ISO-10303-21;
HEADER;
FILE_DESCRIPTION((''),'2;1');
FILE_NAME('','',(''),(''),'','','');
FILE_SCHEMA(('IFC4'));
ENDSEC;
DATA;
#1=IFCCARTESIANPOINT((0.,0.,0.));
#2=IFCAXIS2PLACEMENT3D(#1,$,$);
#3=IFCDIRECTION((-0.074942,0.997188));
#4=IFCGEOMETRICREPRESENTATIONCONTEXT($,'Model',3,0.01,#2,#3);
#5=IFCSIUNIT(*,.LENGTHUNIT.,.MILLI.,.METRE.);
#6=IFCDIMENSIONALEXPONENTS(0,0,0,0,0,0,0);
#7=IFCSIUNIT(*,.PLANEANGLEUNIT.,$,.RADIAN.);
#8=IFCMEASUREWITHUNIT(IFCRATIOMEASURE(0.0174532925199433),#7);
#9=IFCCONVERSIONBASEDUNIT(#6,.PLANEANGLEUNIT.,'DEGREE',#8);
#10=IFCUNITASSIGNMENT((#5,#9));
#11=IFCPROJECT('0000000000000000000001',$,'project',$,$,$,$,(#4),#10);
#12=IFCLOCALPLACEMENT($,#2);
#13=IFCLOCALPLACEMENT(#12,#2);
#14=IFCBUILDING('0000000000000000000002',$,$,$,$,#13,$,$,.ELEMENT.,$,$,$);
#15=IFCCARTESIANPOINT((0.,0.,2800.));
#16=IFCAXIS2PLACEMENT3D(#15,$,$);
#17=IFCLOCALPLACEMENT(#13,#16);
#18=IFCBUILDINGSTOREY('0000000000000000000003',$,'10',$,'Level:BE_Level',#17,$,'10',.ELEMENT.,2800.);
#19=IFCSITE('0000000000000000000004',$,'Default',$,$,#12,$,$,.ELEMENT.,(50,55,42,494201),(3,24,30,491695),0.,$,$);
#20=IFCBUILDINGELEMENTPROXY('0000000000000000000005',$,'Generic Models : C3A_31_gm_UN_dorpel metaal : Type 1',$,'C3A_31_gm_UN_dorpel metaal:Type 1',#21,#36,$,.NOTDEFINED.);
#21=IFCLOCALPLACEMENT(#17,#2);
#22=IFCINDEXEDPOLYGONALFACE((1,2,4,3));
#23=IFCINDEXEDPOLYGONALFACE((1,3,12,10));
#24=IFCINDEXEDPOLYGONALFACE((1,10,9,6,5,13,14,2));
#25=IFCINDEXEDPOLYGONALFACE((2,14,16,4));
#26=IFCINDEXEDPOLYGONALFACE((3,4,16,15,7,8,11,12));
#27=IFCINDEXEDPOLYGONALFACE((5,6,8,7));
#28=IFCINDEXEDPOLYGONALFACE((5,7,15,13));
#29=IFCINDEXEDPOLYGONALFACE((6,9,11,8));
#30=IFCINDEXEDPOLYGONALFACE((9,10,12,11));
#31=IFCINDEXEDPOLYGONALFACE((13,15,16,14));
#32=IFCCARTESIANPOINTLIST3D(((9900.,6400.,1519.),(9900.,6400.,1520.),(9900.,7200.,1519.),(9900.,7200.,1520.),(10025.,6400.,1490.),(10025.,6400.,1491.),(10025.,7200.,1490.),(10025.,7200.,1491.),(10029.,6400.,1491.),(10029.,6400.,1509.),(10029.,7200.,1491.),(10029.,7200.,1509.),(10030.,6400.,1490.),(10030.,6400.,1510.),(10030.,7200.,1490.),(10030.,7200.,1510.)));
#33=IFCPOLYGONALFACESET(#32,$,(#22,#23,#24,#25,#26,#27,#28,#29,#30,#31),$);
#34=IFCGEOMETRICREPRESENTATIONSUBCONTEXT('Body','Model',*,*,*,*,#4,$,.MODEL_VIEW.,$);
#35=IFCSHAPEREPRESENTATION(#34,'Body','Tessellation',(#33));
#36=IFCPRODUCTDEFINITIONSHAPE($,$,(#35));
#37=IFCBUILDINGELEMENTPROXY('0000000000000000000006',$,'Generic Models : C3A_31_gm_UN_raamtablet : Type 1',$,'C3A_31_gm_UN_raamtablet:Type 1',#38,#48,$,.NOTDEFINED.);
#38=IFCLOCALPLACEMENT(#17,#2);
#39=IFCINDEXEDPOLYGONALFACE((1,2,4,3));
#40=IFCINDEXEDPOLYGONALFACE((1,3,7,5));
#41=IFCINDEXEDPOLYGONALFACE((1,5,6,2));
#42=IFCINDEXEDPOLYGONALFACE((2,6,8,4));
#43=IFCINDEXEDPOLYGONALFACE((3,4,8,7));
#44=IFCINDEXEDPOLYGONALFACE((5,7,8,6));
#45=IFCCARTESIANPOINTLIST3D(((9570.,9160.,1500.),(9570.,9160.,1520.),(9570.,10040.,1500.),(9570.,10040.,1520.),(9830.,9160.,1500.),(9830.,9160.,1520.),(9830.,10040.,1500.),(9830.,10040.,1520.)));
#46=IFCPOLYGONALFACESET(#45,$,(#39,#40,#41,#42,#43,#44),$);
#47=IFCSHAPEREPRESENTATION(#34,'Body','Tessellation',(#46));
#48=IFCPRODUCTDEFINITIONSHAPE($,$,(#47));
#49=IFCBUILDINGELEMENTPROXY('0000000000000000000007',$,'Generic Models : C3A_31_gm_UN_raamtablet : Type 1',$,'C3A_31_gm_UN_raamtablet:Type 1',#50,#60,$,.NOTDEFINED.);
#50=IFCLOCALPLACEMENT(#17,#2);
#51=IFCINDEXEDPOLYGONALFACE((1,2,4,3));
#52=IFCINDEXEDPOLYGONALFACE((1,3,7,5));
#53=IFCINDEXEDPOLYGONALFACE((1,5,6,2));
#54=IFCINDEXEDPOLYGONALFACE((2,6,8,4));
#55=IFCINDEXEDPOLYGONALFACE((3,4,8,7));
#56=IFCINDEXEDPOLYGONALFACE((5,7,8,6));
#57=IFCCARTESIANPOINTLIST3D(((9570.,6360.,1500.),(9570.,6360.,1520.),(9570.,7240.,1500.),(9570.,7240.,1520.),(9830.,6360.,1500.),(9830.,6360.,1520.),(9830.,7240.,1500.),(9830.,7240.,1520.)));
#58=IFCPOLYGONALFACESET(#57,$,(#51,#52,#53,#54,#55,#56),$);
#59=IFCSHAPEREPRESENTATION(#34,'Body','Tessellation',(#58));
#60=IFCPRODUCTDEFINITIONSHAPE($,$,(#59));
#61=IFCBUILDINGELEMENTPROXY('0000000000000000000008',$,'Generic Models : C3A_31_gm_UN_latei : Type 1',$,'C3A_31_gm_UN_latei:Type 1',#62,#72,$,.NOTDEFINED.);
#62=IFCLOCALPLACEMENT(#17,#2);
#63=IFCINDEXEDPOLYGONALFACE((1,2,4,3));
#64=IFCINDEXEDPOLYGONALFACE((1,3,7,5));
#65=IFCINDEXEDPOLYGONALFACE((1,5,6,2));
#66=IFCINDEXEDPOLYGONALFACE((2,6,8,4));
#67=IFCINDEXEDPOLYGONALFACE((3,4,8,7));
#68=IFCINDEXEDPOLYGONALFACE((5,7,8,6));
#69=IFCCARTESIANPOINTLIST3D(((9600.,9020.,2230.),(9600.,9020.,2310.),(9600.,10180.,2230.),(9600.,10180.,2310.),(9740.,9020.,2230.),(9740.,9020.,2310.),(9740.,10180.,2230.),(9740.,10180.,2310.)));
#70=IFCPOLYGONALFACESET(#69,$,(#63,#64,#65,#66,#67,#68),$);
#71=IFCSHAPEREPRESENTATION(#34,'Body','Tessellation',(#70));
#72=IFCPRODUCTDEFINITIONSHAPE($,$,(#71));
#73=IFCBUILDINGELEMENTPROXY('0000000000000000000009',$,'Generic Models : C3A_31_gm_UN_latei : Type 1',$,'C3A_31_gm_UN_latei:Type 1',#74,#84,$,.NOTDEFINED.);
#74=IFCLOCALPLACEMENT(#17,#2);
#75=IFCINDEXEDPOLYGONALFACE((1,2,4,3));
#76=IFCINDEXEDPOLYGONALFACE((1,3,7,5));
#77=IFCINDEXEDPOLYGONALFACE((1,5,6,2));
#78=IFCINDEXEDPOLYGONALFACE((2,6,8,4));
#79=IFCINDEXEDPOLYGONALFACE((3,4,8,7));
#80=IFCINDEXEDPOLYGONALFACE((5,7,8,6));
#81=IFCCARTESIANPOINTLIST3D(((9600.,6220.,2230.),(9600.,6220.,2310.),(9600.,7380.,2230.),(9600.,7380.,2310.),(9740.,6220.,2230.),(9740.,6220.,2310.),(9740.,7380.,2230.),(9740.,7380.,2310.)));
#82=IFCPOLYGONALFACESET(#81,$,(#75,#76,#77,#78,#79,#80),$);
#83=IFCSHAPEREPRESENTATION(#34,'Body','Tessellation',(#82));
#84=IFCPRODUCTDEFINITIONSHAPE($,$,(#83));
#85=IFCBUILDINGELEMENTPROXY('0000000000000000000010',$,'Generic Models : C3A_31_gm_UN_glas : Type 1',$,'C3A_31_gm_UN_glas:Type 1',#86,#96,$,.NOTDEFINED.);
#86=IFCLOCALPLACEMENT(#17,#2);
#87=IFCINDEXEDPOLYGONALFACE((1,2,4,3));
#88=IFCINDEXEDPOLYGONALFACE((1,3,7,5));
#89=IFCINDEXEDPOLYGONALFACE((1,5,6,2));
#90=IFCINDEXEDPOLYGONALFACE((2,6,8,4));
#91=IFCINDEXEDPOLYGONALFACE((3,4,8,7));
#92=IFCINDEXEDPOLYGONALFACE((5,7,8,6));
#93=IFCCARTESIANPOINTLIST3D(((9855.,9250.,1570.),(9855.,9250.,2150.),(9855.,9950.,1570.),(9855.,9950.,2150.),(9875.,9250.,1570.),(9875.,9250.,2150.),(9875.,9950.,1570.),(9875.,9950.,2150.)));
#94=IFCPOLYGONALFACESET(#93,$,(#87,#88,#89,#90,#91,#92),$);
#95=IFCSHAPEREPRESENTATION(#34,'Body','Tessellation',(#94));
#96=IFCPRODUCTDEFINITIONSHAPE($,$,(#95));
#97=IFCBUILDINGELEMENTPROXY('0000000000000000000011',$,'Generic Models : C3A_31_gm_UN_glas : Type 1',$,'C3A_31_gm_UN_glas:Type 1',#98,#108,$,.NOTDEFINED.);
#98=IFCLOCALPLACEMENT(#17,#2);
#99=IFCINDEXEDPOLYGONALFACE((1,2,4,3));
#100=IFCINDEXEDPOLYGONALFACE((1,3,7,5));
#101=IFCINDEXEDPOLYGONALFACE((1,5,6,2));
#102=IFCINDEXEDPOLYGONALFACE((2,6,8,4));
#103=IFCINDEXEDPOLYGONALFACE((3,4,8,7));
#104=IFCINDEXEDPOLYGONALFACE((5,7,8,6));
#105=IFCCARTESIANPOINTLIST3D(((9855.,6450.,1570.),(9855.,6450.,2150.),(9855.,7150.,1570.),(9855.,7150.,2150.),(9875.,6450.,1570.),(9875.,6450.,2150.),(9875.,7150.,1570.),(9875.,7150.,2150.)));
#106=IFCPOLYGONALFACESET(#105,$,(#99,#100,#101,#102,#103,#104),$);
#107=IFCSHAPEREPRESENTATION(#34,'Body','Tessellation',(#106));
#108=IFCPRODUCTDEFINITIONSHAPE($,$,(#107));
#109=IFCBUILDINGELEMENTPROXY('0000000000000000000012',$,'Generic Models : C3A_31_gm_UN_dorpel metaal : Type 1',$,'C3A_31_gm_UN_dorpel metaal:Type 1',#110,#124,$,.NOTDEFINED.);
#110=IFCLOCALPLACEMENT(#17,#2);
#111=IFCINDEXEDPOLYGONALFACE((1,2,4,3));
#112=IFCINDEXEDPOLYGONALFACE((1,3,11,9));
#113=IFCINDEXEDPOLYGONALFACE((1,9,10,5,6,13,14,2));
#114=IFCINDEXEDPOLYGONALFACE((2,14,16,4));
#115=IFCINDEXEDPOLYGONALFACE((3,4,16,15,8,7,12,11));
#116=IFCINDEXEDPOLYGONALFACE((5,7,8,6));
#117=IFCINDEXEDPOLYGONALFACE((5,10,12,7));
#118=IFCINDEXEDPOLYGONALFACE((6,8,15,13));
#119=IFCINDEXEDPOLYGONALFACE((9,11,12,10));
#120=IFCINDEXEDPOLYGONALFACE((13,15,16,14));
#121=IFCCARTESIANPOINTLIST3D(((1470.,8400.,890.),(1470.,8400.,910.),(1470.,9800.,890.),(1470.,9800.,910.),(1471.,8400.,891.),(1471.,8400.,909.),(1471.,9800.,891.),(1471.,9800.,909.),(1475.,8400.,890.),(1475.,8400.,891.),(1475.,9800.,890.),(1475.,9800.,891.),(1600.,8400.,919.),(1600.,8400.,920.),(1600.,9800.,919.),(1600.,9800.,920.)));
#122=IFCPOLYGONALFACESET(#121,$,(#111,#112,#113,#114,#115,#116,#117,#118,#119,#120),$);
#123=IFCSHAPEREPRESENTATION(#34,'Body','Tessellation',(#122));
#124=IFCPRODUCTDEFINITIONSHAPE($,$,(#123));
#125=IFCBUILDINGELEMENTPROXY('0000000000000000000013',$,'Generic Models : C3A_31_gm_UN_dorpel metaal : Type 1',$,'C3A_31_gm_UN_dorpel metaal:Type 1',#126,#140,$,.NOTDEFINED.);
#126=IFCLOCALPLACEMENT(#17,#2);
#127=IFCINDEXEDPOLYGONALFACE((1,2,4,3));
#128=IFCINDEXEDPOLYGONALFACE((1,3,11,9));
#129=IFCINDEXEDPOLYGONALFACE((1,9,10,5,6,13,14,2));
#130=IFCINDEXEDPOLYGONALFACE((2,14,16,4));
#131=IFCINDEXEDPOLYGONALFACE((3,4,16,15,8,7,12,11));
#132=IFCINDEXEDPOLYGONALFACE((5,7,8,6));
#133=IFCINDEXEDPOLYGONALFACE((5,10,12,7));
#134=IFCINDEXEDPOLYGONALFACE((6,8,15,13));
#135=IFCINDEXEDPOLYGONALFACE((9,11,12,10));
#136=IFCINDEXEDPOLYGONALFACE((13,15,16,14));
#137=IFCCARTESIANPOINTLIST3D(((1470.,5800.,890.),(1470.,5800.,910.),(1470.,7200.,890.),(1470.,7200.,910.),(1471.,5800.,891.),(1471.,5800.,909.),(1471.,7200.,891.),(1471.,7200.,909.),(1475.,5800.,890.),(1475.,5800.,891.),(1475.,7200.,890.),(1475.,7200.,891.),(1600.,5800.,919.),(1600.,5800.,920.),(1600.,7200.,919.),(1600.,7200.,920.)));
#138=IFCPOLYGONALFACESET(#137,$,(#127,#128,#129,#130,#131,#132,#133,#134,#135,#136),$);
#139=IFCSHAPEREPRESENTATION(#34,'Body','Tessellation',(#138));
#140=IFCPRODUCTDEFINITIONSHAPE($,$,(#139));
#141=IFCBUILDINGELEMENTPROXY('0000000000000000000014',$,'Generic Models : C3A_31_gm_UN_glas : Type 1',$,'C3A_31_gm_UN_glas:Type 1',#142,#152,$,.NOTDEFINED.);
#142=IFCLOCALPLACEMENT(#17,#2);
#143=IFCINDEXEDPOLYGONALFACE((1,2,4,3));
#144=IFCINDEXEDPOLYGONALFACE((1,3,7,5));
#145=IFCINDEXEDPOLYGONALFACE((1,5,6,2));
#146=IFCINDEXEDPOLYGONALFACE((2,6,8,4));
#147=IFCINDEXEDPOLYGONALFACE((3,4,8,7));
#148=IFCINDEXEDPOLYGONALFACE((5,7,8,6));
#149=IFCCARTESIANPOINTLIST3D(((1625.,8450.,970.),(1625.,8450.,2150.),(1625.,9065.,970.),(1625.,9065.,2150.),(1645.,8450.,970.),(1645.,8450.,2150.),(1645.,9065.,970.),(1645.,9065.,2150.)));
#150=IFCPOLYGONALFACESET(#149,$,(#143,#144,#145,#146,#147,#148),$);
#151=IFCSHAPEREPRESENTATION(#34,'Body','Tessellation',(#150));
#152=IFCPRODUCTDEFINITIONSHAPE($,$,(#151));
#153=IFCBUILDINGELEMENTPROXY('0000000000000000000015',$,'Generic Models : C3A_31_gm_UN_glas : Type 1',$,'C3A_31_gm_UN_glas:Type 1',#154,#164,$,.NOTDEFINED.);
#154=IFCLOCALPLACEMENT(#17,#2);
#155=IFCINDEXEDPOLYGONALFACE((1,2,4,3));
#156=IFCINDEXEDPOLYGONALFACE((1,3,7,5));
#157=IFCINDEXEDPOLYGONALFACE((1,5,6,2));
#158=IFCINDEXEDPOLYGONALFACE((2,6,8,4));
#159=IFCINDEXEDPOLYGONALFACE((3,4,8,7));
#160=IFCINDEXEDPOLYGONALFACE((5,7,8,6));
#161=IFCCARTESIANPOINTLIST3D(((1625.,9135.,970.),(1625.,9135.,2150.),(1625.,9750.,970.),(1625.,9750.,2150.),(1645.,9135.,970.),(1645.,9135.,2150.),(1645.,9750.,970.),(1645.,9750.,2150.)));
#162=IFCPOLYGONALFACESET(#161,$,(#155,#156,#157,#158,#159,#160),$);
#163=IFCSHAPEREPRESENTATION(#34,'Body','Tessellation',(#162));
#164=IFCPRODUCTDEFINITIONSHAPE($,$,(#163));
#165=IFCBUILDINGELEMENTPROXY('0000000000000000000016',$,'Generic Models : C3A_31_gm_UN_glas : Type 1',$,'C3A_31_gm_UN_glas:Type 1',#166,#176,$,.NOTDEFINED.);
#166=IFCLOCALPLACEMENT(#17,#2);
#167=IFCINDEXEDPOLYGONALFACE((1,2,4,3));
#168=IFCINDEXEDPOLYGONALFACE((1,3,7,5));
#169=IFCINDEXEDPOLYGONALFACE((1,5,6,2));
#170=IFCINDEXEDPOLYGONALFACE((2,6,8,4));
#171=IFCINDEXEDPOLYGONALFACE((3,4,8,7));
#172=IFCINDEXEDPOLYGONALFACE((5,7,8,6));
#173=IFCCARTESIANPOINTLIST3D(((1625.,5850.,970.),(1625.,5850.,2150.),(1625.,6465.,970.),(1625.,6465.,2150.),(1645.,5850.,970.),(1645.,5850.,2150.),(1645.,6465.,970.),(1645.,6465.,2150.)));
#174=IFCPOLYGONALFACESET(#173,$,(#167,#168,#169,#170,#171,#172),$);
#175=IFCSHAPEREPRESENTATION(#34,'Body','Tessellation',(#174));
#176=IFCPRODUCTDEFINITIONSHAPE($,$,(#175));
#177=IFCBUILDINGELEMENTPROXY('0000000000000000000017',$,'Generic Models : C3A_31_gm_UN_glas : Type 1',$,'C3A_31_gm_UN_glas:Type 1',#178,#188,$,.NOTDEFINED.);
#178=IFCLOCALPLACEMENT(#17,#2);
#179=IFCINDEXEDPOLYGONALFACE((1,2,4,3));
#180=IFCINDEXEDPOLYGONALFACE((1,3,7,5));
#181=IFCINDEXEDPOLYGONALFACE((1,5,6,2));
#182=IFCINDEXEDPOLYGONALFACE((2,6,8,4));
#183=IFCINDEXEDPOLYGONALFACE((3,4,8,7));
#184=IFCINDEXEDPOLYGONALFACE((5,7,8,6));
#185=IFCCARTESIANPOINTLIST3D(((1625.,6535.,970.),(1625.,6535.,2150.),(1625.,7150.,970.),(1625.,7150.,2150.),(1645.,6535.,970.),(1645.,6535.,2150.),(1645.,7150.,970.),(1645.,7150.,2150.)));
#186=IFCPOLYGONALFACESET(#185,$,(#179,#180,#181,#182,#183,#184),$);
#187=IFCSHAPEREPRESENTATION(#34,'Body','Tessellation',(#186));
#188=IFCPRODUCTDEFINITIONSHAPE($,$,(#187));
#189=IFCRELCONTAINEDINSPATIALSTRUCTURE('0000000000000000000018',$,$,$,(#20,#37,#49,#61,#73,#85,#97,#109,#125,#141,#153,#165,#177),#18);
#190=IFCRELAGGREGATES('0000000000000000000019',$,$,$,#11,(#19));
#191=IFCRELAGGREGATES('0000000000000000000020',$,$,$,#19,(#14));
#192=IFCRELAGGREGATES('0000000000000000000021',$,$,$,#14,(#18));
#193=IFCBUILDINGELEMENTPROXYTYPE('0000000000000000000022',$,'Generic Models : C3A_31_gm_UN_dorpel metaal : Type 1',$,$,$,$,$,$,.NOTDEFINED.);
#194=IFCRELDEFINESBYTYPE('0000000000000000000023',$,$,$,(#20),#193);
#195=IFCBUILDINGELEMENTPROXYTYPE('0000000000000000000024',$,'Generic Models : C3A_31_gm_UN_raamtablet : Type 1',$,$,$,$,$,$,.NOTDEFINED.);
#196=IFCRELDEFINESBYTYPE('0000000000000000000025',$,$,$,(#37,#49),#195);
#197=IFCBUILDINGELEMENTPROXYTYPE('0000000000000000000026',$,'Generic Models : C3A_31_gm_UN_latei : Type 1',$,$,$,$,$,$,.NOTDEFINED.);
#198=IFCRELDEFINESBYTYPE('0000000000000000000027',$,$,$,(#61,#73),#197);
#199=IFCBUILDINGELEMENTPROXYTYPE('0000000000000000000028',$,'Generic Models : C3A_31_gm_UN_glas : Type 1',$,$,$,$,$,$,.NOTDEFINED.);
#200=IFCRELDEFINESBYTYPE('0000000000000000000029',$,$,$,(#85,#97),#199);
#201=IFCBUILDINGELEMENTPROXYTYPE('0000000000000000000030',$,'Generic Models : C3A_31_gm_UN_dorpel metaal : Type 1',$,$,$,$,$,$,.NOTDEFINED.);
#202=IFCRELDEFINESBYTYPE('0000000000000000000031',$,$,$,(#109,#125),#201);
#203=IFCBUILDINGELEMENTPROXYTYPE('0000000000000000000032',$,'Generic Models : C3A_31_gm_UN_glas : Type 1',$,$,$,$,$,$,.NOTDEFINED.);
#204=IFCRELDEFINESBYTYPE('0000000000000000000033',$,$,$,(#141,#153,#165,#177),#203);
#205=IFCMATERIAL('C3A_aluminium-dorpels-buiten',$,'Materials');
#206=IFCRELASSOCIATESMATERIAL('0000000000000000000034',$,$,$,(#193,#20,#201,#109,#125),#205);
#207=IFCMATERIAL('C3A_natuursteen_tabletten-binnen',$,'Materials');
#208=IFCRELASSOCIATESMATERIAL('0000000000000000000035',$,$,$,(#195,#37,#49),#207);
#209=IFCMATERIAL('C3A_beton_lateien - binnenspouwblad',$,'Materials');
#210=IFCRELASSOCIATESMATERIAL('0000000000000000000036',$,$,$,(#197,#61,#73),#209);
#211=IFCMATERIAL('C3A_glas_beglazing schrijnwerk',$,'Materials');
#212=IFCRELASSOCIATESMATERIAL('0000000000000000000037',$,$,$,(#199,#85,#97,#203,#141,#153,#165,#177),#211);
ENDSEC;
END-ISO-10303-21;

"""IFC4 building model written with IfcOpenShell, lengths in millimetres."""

from ifc_helpers import new_model, entity, si_unit, converted_unit, direction, frame, origin, origin_2d_with_axis, place, context, subcontext, project, spatial, polyline, rectangle, outline, extrude, source, transform, mapped, material, type_object, type_shapes, element, save


model = new_model("IFC4")

# Units and contexts
model_context = context("Model", 3, precision=0.01, world=origin(), true_north=direction((-0.074942, 0.997188)))
body_context = subcontext(model_context, "Body", "Model", "MODEL_VIEW")
ifc_project = project(units=[si_unit("LENGTHUNIT", "METRE", prefix="MILLI"), converted_unit("PLANEANGLEUNIT", "DEGREE", entity("IfcRatioMeasure", 0.0174532925199433), si_unit("PLANEANGLEUNIT", "RADIAN"), dimensions=[0, 0, 0, 0, 0, 0, 0])], contexts=[model_context])

# Site, building, storey
site_placement = place(None, origin())
site = spatial("IfcSite", under=ifc_project, at=site_placement, Name="Default", CompositionType="ELEMENT", RefLatitude=(50, 55, 42, 494201), RefLongitude=(3, 24, 30, 491695), RefElevation=0.0)
building_placement = place(site_placement, origin())
building = spatial("IfcBuilding", under=site, at=building_placement, CompositionType="ELEMENT")
storey_placement = place(building_placement, frame((0.0, 0.0, 2800.0)))
storey = spatial("IfcBuildingStorey", under=building, at=storey_placement, Name="10", ObjectType="Level:BE_Level", LongName="10", CompositionType="ELEMENT", Elevation=2800.0)

# Building element proxies
ifc_material_1 = material(Name="C3A_natuursteen_tabletten-binnen", Category="Materials")
ifc_material_2 = material(Name="C3A_beton_lateien - binnenspouwblad", Category="Materials")
ifc_material_3 = material(Name="C3A_glas_beglazing schrijnwerk", Category="Materials")
ifc_material_4 = material(Name="C3A_aluminium-dorpels-buiten", Category="Materials")
building_element_proxy_type_1 = type_object("IfcBuildingElementProxyType", Name="Generic Models : C3A_31_gm_UN_dorpel metaal : Type 1", PredefinedType="NOTDEFINED", material=ifc_material_4)
shared_shape_1 = source(origin(), body_context, "Body", "SweptSolid", [
    extrude(outline(polyline([(-33.3, -10.1), (97.1, -10.1), (97.0, -9.1), (-32.4, -9.1), (-33.8, 8.9), (-29.8, 9.2), (-29.9, 10.2), (-34.9, 9.9), (-33.3, -10.1)])), frame((-400.0, 96.0, 2.5), z_axis=(1.0, 0.0, 0.0), x_axis=(0.0, -0.997054, 0.076696)), (0.0, 0.0, 1.0), 800.0),
])
type_shapes(building_element_proxy_type_1, [shared_shape_1])
for number, where, z_axis, x_axis, name in (
    (1, (9900.0, 6800.0, 1500.0), (0.0, 0.0, 1.0), (0.0, -1.0, 0.0), "Generic Models : C3A_31_gm_UN_dorpel metaal : Type 1"),
):
    element("IfcBuildingElementProxy", number, at=place(storey_placement, frame(where, z_axis=z_axis, x_axis=x_axis)), inside=storey, type_object=building_element_proxy_type_1, material=ifc_material_4, Name=name, ObjectType="C3A_31_gm_UN_dorpel metaal:Type 1", PredefinedType="NOTDEFINED", context=body_context, shape_type="MappedRepresentation", body=[
        mapped(shared_shape_1, transform((0.0, 0.0, 0.0), scale=1.0)),
    ])
building_element_proxy_type_2 = type_object("IfcBuildingElementProxyType", Name="Generic Models : C3A_31_gm_UN_raamtablet : Type 1", PredefinedType="NOTDEFINED", material=ifc_material_1)
shared_shape_2 = source(origin(), body_context, "Body", "SweptSolid", [
    extrude(rectangle(XDim=880.0, YDim=260.0, at=origin_2d_with_axis()), frame((0.0, 130.0, 0.0), z_axis=(0.0, 0.0, 1.0), x_axis=(-1.0, 0.0, 0.0)), (0.0, 0.0, 1.0), 20.0),
])
type_shapes(building_element_proxy_type_2, [shared_shape_2])
for number, where, z_axis, x_axis, name in (
    (2, (9570.0, 9600.0, 1500.0), (0.0, 0.0, 1.0), (0.0, -1.0, 0.0), "Generic Models : C3A_31_gm_UN_raamtablet : Type 1"),
    (3, (9570.0, 6800.0, 1500.0), (0.0, 0.0, 1.0), (0.0, -1.0, 0.0), "Generic Models : C3A_31_gm_UN_raamtablet : Type 1"),
):
    element("IfcBuildingElementProxy", number, at=place(storey_placement, frame(where, z_axis=z_axis, x_axis=x_axis)), inside=storey, type_object=building_element_proxy_type_2, material=ifc_material_1, Name=name, ObjectType="C3A_31_gm_UN_raamtablet:Type 1", PredefinedType="NOTDEFINED", context=body_context, shape_type="MappedRepresentation", body=[
        mapped(shared_shape_2, transform((0.0, 0.0, 0.0), scale=1.0)),
    ])
building_element_proxy_type_3 = type_object("IfcBuildingElementProxyType", Name="Generic Models : C3A_31_gm_UN_latei : Type 1", PredefinedType="NOTDEFINED", material=ifc_material_2)
shared_shape_3 = source(origin(), body_context, "Body", "SweptSolid", [
    extrude(rectangle(XDim=1160.0, YDim=140.0, at=origin_2d_with_axis()), frame((0.0, 70.0, 0.0), z_axis=(0.0, 0.0, 1.0), x_axis=(-1.0, 0.0, 0.0)), (0.0, 0.0, 1.0), 80.0),
])
type_shapes(building_element_proxy_type_3, [shared_shape_3])
for number, where, z_axis, x_axis, name in (
    (4, (9600.0, 9600.0, 2230.0), (0.0, 0.0, 1.0), (0.0, -1.0, 0.0), "Generic Models : C3A_31_gm_UN_latei : Type 1"),
    (5, (9600.0, 6800.0, 2230.0), (0.0, 0.0, 1.0), (0.0, -1.0, 0.0), "Generic Models : C3A_31_gm_UN_latei : Type 1"),
):
    element("IfcBuildingElementProxy", number, at=place(storey_placement, frame(where, z_axis=z_axis, x_axis=x_axis)), inside=storey, type_object=building_element_proxy_type_3, material=ifc_material_2, Name=name, ObjectType="C3A_31_gm_UN_latei:Type 1", PredefinedType="NOTDEFINED", context=body_context, shape_type="MappedRepresentation", body=[
        mapped(shared_shape_3, transform((0.0, 0.0, 0.0), scale=1.0)),
    ])
building_element_proxy_type_4 = type_object("IfcBuildingElementProxyType", Name="Generic Models : C3A_31_gm_UN_glas : Type 1", PredefinedType="NOTDEFINED", material=ifc_material_3)
shared_shape_4 = source(origin(), body_context, "Body", "SweptSolid", [
    extrude(rectangle(XDim=700.0, YDim=20.0, at=origin_2d_with_axis()), frame((350.0, 10.0, 0.0), z_axis=(0.0, 0.0, 1.0), x_axis=(-1.0, 0.0, 0.0)), (0.0, 0.0, 1.0), 580.0),
])
type_shapes(building_element_proxy_type_4, [shared_shape_4])
for number, where, z_axis, x_axis, name in (
    (6, (9855.0, 9950.0, 1570.0), (0.0, 0.0, 1.0), (0.0, -1.0, 0.0), "Generic Models : C3A_31_gm_UN_glas : Type 1"),
    (7, (9855.0, 7150.0, 1570.0), (0.0, 0.0, 1.0), (0.0, -1.0, 0.0), "Generic Models : C3A_31_gm_UN_glas : Type 1"),
):
    element("IfcBuildingElementProxy", number, at=place(storey_placement, frame(where, z_axis=z_axis, x_axis=x_axis)), inside=storey, type_object=building_element_proxy_type_4, material=ifc_material_3, Name=name, ObjectType="C3A_31_gm_UN_glas:Type 1", PredefinedType="NOTDEFINED", context=body_context, shape_type="MappedRepresentation", body=[
        mapped(shared_shape_4, transform((0.0, 0.0, 0.0), scale=1.0)),
    ])
building_element_proxy_type_5 = type_object("IfcBuildingElementProxyType", Name="Generic Models : C3A_31_gm_UN_dorpel metaal : Type 1", PredefinedType="NOTDEFINED", material=ifc_material_4)
shared_shape_5 = source(origin(), body_context, "Body", "SweptSolid", [
    extrude(outline(polyline([(-33.3, -10.1), (97.1, -10.1), (97.0, -9.1), (-32.4, -9.1), (-33.8, 8.9), (-29.8, 9.2), (-29.9, 10.2), (-34.9, 9.9), (-33.3, -10.1)])), frame((-700.0, 96.0, 2.5), z_axis=(1.0, 0.0, 0.0), x_axis=(0.0, -0.997054, 0.076696)), (0.0, 0.0, 1.0), 1400.0),
])
type_shapes(building_element_proxy_type_5, [shared_shape_5])
for number, where, z_axis, x_axis, name in (
    (8, (1600.0, 9100.0, 900.0), (0.0, 0.0, 1.0), (0.0, 1.0, 0.0), "Generic Models : C3A_31_gm_UN_dorpel metaal : Type 1"),
    (9, (1600.0, 6500.0, 900.0), (0.0, 0.0, 1.0), (0.0, 1.0, 0.0), "Generic Models : C3A_31_gm_UN_dorpel metaal : Type 1"),
):
    element("IfcBuildingElementProxy", number, at=place(storey_placement, frame(where, z_axis=z_axis, x_axis=x_axis)), inside=storey, type_object=building_element_proxy_type_5, material=ifc_material_4, Name=name, ObjectType="C3A_31_gm_UN_dorpel metaal:Type 1", PredefinedType="NOTDEFINED", context=body_context, shape_type="MappedRepresentation", body=[
        mapped(shared_shape_5, transform((0.0, 0.0, 0.0), scale=1.0)),
    ])
building_element_proxy_type_6 = type_object("IfcBuildingElementProxyType", Name="Generic Models : C3A_31_gm_UN_glas : Type 1", PredefinedType="NOTDEFINED", material=ifc_material_3)
shared_shape_6 = source(origin(), body_context, "Body", "SweptSolid", [
    extrude(rectangle(XDim=615.0, YDim=20.0, at=origin_2d_with_axis()), frame((307.5, 10.0, 0.0), z_axis=(0.0, 0.0, 1.0), x_axis=(-1.0, 0.0, 0.0)), (0.0, 0.0, 1.0), 1180.0),
])
type_shapes(building_element_proxy_type_6, [shared_shape_6])
for number, where, z_axis, x_axis, name in (
    (10, (1645.0, 8450.0, 970.0), (0.0, 0.0, 1.0), (0.0, 1.0, 0.0), "Generic Models : C3A_31_gm_UN_glas : Type 1"),
    (11, (1645.0, 9135.0, 970.0), (0.0, 0.0, 1.0), (0.0, 1.0, 0.0), "Generic Models : C3A_31_gm_UN_glas : Type 1"),
    (12, (1645.0, 5850.0, 970.0), (0.0, 0.0, 1.0), (0.0, 1.0, 0.0), "Generic Models : C3A_31_gm_UN_glas : Type 1"),
    (13, (1645.0, 6535.0, 970.0), (0.0, 0.0, 1.0), (0.0, 1.0, 0.0), "Generic Models : C3A_31_gm_UN_glas : Type 1"),
):
    element("IfcBuildingElementProxy", number, at=place(storey_placement, frame(where, z_axis=z_axis, x_axis=x_axis)), inside=storey, type_object=building_element_proxy_type_6, material=ifc_material_3, Name=name, ObjectType="C3A_31_gm_UN_glas:Type 1", PredefinedType="NOTDEFINED", context=body_context, shape_type="MappedRepresentation", body=[
        mapped(shared_shape_6, transform((0.0, 0.0, 0.0), scale=1.0)),
    ])

save(model, "model.ifc")
